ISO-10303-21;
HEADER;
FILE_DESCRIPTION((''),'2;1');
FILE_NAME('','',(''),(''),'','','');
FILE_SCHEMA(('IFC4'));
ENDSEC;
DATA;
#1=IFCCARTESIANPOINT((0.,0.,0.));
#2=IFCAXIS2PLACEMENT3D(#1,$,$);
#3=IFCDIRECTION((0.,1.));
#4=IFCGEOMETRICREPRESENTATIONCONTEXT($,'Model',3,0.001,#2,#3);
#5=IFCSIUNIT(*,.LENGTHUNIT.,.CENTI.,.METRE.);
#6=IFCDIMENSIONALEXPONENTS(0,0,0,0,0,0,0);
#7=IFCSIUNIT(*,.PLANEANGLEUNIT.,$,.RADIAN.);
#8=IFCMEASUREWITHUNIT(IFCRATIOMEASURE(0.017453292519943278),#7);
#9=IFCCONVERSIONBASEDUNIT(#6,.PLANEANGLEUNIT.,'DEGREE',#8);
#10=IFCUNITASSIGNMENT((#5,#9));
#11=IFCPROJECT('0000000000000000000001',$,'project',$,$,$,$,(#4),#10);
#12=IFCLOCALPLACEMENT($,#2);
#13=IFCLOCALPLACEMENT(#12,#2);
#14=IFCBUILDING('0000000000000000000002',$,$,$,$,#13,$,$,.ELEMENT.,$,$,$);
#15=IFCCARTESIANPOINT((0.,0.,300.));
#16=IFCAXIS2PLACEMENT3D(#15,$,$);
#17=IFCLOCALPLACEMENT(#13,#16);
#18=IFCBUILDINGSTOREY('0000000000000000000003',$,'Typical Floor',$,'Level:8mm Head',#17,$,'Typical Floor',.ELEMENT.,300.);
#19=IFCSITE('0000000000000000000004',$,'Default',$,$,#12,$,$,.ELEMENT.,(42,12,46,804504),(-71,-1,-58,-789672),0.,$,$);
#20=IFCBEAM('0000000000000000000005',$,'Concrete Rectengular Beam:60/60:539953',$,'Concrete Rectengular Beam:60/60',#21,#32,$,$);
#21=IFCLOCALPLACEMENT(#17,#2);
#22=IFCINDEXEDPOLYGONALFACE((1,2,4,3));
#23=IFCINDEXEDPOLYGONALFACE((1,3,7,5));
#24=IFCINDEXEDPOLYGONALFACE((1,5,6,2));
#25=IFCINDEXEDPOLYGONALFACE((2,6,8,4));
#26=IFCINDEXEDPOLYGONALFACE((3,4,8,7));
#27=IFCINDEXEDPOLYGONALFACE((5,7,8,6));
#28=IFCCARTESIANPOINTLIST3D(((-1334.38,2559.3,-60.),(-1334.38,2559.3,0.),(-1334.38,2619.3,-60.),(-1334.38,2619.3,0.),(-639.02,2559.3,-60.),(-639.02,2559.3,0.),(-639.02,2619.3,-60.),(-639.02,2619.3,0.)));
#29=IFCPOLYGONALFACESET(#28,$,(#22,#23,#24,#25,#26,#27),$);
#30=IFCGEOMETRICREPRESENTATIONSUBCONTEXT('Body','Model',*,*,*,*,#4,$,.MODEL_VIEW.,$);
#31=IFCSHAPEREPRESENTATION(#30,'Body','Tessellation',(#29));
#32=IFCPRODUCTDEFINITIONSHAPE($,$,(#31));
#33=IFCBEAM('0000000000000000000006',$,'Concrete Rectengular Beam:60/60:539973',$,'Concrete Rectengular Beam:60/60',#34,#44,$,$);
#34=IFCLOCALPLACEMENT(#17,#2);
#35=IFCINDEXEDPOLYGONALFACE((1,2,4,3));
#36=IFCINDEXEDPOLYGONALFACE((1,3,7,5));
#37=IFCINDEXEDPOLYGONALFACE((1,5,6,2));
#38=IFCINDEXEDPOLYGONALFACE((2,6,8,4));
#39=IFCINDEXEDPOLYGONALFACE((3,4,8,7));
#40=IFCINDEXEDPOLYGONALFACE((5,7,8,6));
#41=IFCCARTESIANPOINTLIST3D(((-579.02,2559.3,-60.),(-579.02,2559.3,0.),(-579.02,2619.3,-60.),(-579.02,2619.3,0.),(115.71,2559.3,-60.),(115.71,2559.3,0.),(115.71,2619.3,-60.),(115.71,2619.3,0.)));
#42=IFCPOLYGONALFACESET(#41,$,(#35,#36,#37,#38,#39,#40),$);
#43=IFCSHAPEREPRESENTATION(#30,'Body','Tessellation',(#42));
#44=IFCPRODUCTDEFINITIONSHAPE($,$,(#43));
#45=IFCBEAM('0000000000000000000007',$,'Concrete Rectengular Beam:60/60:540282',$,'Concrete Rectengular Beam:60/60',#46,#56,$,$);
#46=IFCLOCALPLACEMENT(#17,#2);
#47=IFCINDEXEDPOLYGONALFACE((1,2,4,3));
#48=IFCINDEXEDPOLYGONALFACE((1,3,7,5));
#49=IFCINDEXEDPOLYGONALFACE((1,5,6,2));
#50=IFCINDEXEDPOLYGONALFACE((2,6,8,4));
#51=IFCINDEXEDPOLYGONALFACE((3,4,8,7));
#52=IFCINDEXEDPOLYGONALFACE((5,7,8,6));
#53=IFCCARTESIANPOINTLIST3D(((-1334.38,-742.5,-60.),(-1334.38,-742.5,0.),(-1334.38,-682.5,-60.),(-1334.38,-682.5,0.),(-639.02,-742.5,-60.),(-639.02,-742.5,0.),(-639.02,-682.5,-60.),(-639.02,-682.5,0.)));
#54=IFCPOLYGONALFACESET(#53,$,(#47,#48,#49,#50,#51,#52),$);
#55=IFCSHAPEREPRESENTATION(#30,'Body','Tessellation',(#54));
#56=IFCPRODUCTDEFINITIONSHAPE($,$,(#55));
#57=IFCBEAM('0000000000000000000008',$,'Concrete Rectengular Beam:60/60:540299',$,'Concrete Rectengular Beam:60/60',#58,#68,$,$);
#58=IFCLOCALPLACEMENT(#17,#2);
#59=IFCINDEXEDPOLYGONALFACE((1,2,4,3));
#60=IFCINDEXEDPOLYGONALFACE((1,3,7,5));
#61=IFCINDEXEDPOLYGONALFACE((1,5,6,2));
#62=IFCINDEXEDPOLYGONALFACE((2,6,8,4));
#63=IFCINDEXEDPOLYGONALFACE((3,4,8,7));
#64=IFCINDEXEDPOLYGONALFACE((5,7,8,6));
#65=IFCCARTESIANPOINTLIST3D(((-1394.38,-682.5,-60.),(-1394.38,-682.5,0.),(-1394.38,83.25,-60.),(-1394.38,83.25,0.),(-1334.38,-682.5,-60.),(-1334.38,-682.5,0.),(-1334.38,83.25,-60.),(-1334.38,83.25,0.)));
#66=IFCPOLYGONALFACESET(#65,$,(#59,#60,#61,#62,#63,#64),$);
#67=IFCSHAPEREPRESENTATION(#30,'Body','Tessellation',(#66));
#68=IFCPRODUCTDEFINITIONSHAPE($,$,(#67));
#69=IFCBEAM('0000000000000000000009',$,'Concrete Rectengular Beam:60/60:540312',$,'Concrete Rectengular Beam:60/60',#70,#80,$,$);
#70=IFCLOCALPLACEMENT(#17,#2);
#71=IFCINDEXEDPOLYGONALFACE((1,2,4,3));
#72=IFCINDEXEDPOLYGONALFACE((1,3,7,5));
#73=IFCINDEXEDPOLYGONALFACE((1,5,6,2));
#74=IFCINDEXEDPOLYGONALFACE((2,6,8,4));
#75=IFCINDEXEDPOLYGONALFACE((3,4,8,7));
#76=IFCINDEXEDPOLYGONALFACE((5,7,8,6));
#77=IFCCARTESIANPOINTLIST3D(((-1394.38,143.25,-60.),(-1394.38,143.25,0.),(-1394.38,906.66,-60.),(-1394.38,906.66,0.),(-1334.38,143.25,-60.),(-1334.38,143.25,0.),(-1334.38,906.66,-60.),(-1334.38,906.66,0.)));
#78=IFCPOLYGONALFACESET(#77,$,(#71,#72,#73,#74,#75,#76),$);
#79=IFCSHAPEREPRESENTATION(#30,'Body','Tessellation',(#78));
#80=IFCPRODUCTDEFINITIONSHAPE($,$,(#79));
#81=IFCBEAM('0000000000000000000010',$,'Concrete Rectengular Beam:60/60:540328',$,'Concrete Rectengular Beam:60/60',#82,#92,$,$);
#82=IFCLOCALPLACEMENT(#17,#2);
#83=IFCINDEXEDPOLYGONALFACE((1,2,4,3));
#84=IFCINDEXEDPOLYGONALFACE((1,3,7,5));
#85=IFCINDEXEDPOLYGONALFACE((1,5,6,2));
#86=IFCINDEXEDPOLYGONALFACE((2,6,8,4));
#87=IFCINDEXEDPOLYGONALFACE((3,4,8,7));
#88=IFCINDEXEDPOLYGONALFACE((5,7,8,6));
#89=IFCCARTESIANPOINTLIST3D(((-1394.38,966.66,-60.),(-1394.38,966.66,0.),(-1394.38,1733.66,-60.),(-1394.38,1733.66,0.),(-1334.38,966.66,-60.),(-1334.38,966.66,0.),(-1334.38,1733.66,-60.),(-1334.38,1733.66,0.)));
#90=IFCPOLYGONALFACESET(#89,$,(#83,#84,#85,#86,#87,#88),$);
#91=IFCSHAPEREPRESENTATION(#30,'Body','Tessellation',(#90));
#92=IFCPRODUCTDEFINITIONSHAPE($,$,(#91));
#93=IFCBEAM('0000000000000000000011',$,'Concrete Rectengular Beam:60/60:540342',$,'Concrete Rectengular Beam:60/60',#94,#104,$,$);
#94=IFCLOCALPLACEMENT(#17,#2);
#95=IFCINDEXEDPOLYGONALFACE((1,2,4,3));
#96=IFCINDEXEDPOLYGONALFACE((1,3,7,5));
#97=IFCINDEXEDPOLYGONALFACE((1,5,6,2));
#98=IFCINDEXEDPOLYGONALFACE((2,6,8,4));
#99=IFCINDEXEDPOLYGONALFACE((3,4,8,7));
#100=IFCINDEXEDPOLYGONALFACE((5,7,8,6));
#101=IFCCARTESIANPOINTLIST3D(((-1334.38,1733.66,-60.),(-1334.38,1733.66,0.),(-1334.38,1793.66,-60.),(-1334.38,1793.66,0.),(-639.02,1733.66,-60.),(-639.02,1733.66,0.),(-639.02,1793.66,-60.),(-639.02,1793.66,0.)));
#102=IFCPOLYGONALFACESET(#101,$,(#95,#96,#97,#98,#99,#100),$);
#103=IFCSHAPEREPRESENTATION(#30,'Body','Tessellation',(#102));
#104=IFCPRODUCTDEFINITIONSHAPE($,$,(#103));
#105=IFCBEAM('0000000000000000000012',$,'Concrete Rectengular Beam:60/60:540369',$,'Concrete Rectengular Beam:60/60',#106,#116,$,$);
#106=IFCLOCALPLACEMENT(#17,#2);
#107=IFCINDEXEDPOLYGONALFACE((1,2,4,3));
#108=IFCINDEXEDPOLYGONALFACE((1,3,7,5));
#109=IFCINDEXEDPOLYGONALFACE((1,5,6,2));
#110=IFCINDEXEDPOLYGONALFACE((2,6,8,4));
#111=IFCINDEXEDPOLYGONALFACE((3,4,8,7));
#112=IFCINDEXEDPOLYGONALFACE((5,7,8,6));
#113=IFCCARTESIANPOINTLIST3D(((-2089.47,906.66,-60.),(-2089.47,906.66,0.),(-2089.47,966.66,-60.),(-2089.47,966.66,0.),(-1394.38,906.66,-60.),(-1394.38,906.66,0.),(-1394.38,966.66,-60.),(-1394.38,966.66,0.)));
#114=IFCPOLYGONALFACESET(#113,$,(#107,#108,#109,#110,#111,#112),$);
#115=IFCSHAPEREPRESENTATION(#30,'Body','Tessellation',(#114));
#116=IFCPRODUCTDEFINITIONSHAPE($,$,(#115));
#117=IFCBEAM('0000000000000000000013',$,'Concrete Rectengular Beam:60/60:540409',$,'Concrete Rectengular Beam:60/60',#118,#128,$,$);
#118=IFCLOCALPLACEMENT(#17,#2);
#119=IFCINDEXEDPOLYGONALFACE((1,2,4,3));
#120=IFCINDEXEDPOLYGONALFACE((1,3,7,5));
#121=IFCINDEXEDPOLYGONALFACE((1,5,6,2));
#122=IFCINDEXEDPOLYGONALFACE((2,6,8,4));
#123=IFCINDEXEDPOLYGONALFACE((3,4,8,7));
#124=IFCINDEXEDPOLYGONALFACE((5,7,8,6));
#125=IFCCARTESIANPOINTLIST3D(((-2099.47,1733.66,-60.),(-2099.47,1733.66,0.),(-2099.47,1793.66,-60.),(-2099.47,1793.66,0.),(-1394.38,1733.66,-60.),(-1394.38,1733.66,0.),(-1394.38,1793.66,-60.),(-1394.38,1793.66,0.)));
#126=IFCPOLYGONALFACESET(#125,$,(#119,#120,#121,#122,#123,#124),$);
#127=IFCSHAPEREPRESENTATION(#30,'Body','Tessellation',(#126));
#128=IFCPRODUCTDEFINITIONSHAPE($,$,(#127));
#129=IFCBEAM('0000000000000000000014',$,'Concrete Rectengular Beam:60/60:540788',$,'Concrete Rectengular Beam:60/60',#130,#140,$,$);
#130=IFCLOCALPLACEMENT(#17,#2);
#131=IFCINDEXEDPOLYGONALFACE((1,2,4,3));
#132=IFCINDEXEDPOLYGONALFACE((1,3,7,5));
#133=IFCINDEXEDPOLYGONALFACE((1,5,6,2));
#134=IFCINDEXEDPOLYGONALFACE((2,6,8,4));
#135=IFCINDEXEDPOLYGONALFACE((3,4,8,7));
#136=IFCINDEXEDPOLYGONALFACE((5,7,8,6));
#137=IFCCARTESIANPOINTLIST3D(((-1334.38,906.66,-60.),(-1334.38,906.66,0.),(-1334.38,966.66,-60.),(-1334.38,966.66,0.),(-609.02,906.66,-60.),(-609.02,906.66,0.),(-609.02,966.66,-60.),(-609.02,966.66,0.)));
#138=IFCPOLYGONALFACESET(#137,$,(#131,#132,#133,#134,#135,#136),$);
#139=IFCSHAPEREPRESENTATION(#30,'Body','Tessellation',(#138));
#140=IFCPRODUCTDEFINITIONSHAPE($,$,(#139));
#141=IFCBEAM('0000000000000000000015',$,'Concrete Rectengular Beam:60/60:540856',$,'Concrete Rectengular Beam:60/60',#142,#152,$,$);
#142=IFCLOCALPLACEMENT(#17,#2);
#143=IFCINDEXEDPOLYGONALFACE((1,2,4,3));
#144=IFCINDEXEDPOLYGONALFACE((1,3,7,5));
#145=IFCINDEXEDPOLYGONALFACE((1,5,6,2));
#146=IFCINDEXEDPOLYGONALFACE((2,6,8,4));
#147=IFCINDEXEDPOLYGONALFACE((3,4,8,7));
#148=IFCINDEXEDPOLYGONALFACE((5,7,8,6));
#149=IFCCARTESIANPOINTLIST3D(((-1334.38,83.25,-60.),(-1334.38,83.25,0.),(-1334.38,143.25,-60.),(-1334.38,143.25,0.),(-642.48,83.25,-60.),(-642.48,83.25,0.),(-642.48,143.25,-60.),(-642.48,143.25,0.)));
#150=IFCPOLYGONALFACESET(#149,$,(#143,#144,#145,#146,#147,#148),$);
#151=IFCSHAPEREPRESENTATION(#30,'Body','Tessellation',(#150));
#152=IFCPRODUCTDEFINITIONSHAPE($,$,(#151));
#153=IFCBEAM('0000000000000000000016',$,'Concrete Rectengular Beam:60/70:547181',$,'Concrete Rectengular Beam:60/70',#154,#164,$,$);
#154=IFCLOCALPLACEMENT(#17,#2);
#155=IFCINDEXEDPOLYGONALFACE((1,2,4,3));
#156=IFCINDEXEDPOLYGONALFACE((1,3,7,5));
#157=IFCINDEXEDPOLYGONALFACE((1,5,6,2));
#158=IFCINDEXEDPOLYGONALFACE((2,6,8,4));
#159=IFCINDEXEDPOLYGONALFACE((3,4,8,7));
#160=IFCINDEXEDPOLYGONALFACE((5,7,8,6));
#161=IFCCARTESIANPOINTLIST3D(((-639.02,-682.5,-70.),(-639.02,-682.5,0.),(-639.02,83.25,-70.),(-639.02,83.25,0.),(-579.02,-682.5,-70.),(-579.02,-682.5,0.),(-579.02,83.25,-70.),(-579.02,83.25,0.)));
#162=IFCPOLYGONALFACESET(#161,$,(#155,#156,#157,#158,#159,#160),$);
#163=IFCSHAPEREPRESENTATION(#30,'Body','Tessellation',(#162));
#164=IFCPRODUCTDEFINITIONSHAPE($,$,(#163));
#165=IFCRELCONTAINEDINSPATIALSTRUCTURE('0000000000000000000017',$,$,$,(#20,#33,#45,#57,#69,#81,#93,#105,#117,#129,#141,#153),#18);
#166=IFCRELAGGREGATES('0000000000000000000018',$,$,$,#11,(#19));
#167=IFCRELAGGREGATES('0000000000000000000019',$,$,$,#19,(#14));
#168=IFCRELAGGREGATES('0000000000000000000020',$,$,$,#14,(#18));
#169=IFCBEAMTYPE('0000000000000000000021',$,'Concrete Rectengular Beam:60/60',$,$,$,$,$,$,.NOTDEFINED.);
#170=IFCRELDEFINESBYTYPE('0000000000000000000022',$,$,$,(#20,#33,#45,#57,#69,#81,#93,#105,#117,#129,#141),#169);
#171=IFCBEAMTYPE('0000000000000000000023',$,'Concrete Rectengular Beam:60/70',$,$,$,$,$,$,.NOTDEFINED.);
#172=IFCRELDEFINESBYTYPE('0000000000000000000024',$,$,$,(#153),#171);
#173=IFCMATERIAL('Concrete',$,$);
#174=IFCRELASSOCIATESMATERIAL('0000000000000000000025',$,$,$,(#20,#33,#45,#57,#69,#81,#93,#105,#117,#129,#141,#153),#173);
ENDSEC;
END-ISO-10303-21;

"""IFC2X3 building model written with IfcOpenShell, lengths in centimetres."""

from ifc_helpers import new_model, entity, si_unit, converted_unit, direction, frame, frame_2d, origin, origin_2d_with_axis, place, context, subcontext, project, spatial, rectangle, extrude, material, type_object, element, save


model = new_model("IFC2X3")

# Units and contexts
model_context = context("Model", 3, precision=0.001, world=origin(), true_north=direction((0.0, 1.0)))
body_context = subcontext(model_context, "Body", "Model", "MODEL_VIEW")
ifc_project = project(units=[si_unit("LENGTHUNIT", "METRE", prefix="CENTI"), converted_unit("PLANEANGLEUNIT", "DEGREE", entity("IfcRatioMeasure", 0.017453292519943278), si_unit("PLANEANGLEUNIT", "RADIAN"), dimensions=[0, 0, 0, 0, 0, 0, 0])], contexts=[model_context])

# Site, building, storey
site_placement = place(None, origin())
site = spatial("IfcSite", under=ifc_project, at=site_placement, Name="Default", CompositionType="ELEMENT", RefLatitude=(42, 12, 46, 804504), RefLongitude=(-71, -1, -58, -789672), RefElevation=0.0)
building_placement = place(site_placement, origin())
building = spatial("IfcBuilding", under=site, at=building_placement, CompositionType="ELEMENT")
storey_placement = place(building_placement, frame((0.0, 0.0, 300.0)))
storey = spatial("IfcBuildingStorey", under=building, at=storey_placement, Name="Typical Floor", ObjectType="Level:8mm Head", LongName="Typical Floor", CompositionType="ELEMENT", Elevation=300.0)

# Beams
ifc_material = material(Name="Concrete")
beam_type_1 = type_object("IfcBeamType", Name="Concrete Rectengular Beam:60/60", PredefinedType="NOTDEFINED")
beam_1_placement = place(storey_placement, frame((-1364.38, 2589.3, 0.0)))
element("IfcBeam", 1, at=beam_1_placement, inside=storey, type_object=beam_type_1, material=ifc_material, Name="Concrete Rectengular Beam:60/60:539953", ObjectType="Concrete Rectengular Beam:60/60", context=body_context, shape_type="SweptSolid", body=[
    extrude(rectangle(XDim=60.0, YDim=60.0, at=frame_2d((0.0, 0.0), x_axis=(1.0, 0.0))), frame((30.0, 0.0, -30.0), z_axis=(1.0, 0.0, 0.0), x_axis=(0.0, 0.0, -1.0)), (0.0, 0.0, 1.0), 695.37),
])
beam_2_placement = place(storey_placement, frame((-609.02, 2589.3, 0.0)))
element("IfcBeam", 2, at=beam_2_placement, inside=storey, type_object=beam_type_1, material=ifc_material, Name="Concrete Rectengular Beam:60/60:539973", ObjectType="Concrete Rectengular Beam:60/60", context=body_context, shape_type="SweptSolid", body=[
    extrude(rectangle(XDim=60.0, YDim=60.0, at=frame_2d((0.0, 0.0), x_axis=(1.0, 0.0))), frame((30.0, 0.0, -30.0), z_axis=(1.0, 0.0, 0.0), x_axis=(0.0, 0.0, -1.0)), (0.0, 0.0, 1.0), 694.72),
])
beam_3_placement = place(storey_placement, frame((-609.02, -712.5, 0.0), z_axis=(0.0, 0.0, 1.0), x_axis=(-1.0, 0.0, 0.0)))
element("IfcBeam", 3, at=beam_3_placement, inside=storey, type_object=beam_type_1, material=ifc_material, Name="Concrete Rectengular Beam:60/60:540282", ObjectType="Concrete Rectengular Beam:60/60", context=body_context, shape_type="SweptSolid", body=[
    extrude(rectangle(XDim=60.0, YDim=60.0, at=frame_2d((0.0, 0.0), x_axis=(1.0, 0.0))), frame((30.0, 0.0, -30.0), z_axis=(1.0, 0.0, 0.0), x_axis=(0.0, 0.0, -1.0)), (0.0, 0.0, 1.0), 695.37),
])
beam_4_placement = place(storey_placement, frame((-1364.38, -712.5, 0.0), z_axis=(0.0, 0.0, 1.0), x_axis=(0.0, 1.0, 0.0)))
element("IfcBeam", 4, at=beam_4_placement, inside=storey, type_object=beam_type_1, material=ifc_material, Name="Concrete Rectengular Beam:60/60:540299", ObjectType="Concrete Rectengular Beam:60/60", context=body_context, shape_type="SweptSolid", body=[
    extrude(rectangle(XDim=60.0, YDim=60.0, at=frame_2d((0.0, 0.0), x_axis=(1.0, 0.0))), frame((30.0, 0.0, -30.0), z_axis=(1.0, 0.0, 0.0), x_axis=(0.0, 0.0, -1.0)), (0.0, 0.0, 1.0), 765.75),
])
beam_5_placement = place(storey_placement, frame((-1364.38, 113.25, 0.0), z_axis=(0.0, 0.0, 1.0), x_axis=(0.0, 1.0, 0.0)))
element("IfcBeam", 5, at=beam_5_placement, inside=storey, type_object=beam_type_1, material=ifc_material, Name="Concrete Rectengular Beam:60/60:540312", ObjectType="Concrete Rectengular Beam:60/60", context=body_context, shape_type="SweptSolid", body=[
    extrude(rectangle(XDim=60.0, YDim=60.0, at=frame_2d((0.0, 0.0), x_axis=(1.0, 0.0))), frame((30.0, 0.0, -30.0), z_axis=(1.0, 0.0, 0.0), x_axis=(0.0, 0.0, -1.0)), (0.0, 0.0, 1.0), 763.41),
])
beam_6_placement = place(storey_placement, frame((-1364.38, 936.66, 0.0), z_axis=(0.0, 0.0, 1.0), x_axis=(0.0, 1.0, 0.0)))
element("IfcBeam", 6, at=beam_6_placement, inside=storey, type_object=beam_type_1, material=ifc_material, Name="Concrete Rectengular Beam:60/60:540328", ObjectType="Concrete Rectengular Beam:60/60", context=body_context, shape_type="SweptSolid", body=[
    extrude(rectangle(XDim=60.0, YDim=60.0, at=frame_2d((0.0, 0.0), x_axis=(1.0, 0.0))), frame((30.0, 0.0, -30.0), z_axis=(1.0, 0.0, 0.0), x_axis=(0.0, 0.0, -1.0)), (0.0, 0.0, 1.0), 767.0),
])
beam_7_placement = place(storey_placement, frame((-1364.38, 1763.66, 0.0)))
element("IfcBeam", 7, at=beam_7_placement, inside=storey, type_object=beam_type_1, material=ifc_material, Name="Concrete Rectengular Beam:60/60:540342", ObjectType="Concrete Rectengular Beam:60/60", context=body_context, shape_type="SweptSolid", body=[
    extrude(rectangle(XDim=60.0, YDim=60.0, at=frame_2d((0.0, 0.0), x_axis=(1.0, 0.0))), frame((30.0, 0.0, -30.0), z_axis=(1.0, 0.0, 0.0), x_axis=(0.0, 0.0, -1.0)), (0.0, 0.0, 1.0), 695.37),
])
beam_8_placement = place(storey_placement, frame((-1364.38, 936.66, 0.0), z_axis=(0.0, 0.0, 1.0), x_axis=(-1.0, 0.0, 0.0)))
element("IfcBeam", 8, at=beam_8_placement, inside=storey, type_object=beam_type_1, material=ifc_material, Name="Concrete Rectengular Beam:60/60:540369", ObjectType="Concrete Rectengular Beam:60/60", context=body_context, shape_type="SweptSolid", body=[
    extrude(rectangle(XDim=60.0, YDim=60.0, at=frame_2d((0.0, 0.0), x_axis=(1.0, 0.0))), frame((30.0, 0.0, -30.0), z_axis=(1.0, 0.0, 0.0), x_axis=(0.0, 0.0, -1.0)), (0.0, 0.0, 1.0), 695.09),
])
beam_9_placement = place(storey_placement, frame((-1364.38, 1763.66, 0.0), z_axis=(0.0, 0.0, 1.0), x_axis=(-1.0, 0.0, 0.0)))
element("IfcBeam", 9, at=beam_9_placement, inside=storey, type_object=beam_type_1, material=ifc_material, Name="Concrete Rectengular Beam:60/60:540409", ObjectType="Concrete Rectengular Beam:60/60", context=body_context, shape_type="SweptSolid", body=[
    extrude(rectangle(XDim=60.0, YDim=60.0, at=frame_2d((0.0, 0.0), x_axis=(1.0, 0.0))), frame((30.0, 0.0, -30.0), z_axis=(1.0, 0.0, 0.0), x_axis=(0.0, 0.0, -1.0)), (0.0, 0.0, 1.0), 705.09),
])
beam_10_placement = place(storey_placement, frame((-1364.38, 936.66, 0.0)))
element("IfcBeam", 10, at=beam_10_placement, inside=storey, type_object=beam_type_1, material=ifc_material, Name="Concrete Rectengular Beam:60/60:540788", ObjectType="Concrete Rectengular Beam:60/60", context=body_context, shape_type="SweptSolid", body=[
    extrude(rectangle(XDim=60.0, YDim=60.0, at=frame_2d((0.0, 0.0), x_axis=(1.0, 0.0))), frame((30.0, 0.0, -30.0), z_axis=(1.0, 0.0, 0.0), x_axis=(0.0, 0.0, -1.0)), (0.0, 0.0, 1.0), 725.37),
])
beam_11_placement = place(storey_placement, frame((-1364.38, 113.25, 0.0)))
element("IfcBeam", 11, at=beam_11_placement, inside=storey, type_object=beam_type_1, material=ifc_material, Name="Concrete Rectengular Beam:60/60:540856", ObjectType="Concrete Rectengular Beam:60/60", context=body_context, shape_type="SweptSolid", body=[
    extrude(rectangle(XDim=60.0, YDim=60.0, at=frame_2d((0.0, 0.0), x_axis=(1.0, 0.0))), frame((30.0, 0.0, -30.0), z_axis=(1.0, 0.0, 0.0), x_axis=(0.0, 0.0, -1.0)), (0.0, 0.0, 1.0), 691.9),
])
beam_type_2 = type_object("IfcBeamType", Name="Concrete Rectengular Beam:60/70", PredefinedType="NOTDEFINED")
beam_12_placement = place(storey_placement, frame((-609.02, -712.5, 0.0), z_axis=(0.0, 0.0, 1.0), x_axis=(0.0, 1.0, 0.0)))
element("IfcBeam", 12, at=beam_12_placement, inside=storey, type_object=beam_type_2, material=ifc_material, Name="Concrete Rectengular Beam:60/70:547181", ObjectType="Concrete Rectengular Beam:60/70", context=body_context, shape_type="SweptSolid", body=[
    extrude(rectangle(XDim=70.0, YDim=60.0, at=origin_2d_with_axis()), frame((30.0, 0.0, -35.0), z_axis=(1.0, 0.0, 0.0), x_axis=(0.0, 0.0, -1.0)), (0.0, 0.0, 1.0), 765.75),
])

save(model, "model.ifc")
